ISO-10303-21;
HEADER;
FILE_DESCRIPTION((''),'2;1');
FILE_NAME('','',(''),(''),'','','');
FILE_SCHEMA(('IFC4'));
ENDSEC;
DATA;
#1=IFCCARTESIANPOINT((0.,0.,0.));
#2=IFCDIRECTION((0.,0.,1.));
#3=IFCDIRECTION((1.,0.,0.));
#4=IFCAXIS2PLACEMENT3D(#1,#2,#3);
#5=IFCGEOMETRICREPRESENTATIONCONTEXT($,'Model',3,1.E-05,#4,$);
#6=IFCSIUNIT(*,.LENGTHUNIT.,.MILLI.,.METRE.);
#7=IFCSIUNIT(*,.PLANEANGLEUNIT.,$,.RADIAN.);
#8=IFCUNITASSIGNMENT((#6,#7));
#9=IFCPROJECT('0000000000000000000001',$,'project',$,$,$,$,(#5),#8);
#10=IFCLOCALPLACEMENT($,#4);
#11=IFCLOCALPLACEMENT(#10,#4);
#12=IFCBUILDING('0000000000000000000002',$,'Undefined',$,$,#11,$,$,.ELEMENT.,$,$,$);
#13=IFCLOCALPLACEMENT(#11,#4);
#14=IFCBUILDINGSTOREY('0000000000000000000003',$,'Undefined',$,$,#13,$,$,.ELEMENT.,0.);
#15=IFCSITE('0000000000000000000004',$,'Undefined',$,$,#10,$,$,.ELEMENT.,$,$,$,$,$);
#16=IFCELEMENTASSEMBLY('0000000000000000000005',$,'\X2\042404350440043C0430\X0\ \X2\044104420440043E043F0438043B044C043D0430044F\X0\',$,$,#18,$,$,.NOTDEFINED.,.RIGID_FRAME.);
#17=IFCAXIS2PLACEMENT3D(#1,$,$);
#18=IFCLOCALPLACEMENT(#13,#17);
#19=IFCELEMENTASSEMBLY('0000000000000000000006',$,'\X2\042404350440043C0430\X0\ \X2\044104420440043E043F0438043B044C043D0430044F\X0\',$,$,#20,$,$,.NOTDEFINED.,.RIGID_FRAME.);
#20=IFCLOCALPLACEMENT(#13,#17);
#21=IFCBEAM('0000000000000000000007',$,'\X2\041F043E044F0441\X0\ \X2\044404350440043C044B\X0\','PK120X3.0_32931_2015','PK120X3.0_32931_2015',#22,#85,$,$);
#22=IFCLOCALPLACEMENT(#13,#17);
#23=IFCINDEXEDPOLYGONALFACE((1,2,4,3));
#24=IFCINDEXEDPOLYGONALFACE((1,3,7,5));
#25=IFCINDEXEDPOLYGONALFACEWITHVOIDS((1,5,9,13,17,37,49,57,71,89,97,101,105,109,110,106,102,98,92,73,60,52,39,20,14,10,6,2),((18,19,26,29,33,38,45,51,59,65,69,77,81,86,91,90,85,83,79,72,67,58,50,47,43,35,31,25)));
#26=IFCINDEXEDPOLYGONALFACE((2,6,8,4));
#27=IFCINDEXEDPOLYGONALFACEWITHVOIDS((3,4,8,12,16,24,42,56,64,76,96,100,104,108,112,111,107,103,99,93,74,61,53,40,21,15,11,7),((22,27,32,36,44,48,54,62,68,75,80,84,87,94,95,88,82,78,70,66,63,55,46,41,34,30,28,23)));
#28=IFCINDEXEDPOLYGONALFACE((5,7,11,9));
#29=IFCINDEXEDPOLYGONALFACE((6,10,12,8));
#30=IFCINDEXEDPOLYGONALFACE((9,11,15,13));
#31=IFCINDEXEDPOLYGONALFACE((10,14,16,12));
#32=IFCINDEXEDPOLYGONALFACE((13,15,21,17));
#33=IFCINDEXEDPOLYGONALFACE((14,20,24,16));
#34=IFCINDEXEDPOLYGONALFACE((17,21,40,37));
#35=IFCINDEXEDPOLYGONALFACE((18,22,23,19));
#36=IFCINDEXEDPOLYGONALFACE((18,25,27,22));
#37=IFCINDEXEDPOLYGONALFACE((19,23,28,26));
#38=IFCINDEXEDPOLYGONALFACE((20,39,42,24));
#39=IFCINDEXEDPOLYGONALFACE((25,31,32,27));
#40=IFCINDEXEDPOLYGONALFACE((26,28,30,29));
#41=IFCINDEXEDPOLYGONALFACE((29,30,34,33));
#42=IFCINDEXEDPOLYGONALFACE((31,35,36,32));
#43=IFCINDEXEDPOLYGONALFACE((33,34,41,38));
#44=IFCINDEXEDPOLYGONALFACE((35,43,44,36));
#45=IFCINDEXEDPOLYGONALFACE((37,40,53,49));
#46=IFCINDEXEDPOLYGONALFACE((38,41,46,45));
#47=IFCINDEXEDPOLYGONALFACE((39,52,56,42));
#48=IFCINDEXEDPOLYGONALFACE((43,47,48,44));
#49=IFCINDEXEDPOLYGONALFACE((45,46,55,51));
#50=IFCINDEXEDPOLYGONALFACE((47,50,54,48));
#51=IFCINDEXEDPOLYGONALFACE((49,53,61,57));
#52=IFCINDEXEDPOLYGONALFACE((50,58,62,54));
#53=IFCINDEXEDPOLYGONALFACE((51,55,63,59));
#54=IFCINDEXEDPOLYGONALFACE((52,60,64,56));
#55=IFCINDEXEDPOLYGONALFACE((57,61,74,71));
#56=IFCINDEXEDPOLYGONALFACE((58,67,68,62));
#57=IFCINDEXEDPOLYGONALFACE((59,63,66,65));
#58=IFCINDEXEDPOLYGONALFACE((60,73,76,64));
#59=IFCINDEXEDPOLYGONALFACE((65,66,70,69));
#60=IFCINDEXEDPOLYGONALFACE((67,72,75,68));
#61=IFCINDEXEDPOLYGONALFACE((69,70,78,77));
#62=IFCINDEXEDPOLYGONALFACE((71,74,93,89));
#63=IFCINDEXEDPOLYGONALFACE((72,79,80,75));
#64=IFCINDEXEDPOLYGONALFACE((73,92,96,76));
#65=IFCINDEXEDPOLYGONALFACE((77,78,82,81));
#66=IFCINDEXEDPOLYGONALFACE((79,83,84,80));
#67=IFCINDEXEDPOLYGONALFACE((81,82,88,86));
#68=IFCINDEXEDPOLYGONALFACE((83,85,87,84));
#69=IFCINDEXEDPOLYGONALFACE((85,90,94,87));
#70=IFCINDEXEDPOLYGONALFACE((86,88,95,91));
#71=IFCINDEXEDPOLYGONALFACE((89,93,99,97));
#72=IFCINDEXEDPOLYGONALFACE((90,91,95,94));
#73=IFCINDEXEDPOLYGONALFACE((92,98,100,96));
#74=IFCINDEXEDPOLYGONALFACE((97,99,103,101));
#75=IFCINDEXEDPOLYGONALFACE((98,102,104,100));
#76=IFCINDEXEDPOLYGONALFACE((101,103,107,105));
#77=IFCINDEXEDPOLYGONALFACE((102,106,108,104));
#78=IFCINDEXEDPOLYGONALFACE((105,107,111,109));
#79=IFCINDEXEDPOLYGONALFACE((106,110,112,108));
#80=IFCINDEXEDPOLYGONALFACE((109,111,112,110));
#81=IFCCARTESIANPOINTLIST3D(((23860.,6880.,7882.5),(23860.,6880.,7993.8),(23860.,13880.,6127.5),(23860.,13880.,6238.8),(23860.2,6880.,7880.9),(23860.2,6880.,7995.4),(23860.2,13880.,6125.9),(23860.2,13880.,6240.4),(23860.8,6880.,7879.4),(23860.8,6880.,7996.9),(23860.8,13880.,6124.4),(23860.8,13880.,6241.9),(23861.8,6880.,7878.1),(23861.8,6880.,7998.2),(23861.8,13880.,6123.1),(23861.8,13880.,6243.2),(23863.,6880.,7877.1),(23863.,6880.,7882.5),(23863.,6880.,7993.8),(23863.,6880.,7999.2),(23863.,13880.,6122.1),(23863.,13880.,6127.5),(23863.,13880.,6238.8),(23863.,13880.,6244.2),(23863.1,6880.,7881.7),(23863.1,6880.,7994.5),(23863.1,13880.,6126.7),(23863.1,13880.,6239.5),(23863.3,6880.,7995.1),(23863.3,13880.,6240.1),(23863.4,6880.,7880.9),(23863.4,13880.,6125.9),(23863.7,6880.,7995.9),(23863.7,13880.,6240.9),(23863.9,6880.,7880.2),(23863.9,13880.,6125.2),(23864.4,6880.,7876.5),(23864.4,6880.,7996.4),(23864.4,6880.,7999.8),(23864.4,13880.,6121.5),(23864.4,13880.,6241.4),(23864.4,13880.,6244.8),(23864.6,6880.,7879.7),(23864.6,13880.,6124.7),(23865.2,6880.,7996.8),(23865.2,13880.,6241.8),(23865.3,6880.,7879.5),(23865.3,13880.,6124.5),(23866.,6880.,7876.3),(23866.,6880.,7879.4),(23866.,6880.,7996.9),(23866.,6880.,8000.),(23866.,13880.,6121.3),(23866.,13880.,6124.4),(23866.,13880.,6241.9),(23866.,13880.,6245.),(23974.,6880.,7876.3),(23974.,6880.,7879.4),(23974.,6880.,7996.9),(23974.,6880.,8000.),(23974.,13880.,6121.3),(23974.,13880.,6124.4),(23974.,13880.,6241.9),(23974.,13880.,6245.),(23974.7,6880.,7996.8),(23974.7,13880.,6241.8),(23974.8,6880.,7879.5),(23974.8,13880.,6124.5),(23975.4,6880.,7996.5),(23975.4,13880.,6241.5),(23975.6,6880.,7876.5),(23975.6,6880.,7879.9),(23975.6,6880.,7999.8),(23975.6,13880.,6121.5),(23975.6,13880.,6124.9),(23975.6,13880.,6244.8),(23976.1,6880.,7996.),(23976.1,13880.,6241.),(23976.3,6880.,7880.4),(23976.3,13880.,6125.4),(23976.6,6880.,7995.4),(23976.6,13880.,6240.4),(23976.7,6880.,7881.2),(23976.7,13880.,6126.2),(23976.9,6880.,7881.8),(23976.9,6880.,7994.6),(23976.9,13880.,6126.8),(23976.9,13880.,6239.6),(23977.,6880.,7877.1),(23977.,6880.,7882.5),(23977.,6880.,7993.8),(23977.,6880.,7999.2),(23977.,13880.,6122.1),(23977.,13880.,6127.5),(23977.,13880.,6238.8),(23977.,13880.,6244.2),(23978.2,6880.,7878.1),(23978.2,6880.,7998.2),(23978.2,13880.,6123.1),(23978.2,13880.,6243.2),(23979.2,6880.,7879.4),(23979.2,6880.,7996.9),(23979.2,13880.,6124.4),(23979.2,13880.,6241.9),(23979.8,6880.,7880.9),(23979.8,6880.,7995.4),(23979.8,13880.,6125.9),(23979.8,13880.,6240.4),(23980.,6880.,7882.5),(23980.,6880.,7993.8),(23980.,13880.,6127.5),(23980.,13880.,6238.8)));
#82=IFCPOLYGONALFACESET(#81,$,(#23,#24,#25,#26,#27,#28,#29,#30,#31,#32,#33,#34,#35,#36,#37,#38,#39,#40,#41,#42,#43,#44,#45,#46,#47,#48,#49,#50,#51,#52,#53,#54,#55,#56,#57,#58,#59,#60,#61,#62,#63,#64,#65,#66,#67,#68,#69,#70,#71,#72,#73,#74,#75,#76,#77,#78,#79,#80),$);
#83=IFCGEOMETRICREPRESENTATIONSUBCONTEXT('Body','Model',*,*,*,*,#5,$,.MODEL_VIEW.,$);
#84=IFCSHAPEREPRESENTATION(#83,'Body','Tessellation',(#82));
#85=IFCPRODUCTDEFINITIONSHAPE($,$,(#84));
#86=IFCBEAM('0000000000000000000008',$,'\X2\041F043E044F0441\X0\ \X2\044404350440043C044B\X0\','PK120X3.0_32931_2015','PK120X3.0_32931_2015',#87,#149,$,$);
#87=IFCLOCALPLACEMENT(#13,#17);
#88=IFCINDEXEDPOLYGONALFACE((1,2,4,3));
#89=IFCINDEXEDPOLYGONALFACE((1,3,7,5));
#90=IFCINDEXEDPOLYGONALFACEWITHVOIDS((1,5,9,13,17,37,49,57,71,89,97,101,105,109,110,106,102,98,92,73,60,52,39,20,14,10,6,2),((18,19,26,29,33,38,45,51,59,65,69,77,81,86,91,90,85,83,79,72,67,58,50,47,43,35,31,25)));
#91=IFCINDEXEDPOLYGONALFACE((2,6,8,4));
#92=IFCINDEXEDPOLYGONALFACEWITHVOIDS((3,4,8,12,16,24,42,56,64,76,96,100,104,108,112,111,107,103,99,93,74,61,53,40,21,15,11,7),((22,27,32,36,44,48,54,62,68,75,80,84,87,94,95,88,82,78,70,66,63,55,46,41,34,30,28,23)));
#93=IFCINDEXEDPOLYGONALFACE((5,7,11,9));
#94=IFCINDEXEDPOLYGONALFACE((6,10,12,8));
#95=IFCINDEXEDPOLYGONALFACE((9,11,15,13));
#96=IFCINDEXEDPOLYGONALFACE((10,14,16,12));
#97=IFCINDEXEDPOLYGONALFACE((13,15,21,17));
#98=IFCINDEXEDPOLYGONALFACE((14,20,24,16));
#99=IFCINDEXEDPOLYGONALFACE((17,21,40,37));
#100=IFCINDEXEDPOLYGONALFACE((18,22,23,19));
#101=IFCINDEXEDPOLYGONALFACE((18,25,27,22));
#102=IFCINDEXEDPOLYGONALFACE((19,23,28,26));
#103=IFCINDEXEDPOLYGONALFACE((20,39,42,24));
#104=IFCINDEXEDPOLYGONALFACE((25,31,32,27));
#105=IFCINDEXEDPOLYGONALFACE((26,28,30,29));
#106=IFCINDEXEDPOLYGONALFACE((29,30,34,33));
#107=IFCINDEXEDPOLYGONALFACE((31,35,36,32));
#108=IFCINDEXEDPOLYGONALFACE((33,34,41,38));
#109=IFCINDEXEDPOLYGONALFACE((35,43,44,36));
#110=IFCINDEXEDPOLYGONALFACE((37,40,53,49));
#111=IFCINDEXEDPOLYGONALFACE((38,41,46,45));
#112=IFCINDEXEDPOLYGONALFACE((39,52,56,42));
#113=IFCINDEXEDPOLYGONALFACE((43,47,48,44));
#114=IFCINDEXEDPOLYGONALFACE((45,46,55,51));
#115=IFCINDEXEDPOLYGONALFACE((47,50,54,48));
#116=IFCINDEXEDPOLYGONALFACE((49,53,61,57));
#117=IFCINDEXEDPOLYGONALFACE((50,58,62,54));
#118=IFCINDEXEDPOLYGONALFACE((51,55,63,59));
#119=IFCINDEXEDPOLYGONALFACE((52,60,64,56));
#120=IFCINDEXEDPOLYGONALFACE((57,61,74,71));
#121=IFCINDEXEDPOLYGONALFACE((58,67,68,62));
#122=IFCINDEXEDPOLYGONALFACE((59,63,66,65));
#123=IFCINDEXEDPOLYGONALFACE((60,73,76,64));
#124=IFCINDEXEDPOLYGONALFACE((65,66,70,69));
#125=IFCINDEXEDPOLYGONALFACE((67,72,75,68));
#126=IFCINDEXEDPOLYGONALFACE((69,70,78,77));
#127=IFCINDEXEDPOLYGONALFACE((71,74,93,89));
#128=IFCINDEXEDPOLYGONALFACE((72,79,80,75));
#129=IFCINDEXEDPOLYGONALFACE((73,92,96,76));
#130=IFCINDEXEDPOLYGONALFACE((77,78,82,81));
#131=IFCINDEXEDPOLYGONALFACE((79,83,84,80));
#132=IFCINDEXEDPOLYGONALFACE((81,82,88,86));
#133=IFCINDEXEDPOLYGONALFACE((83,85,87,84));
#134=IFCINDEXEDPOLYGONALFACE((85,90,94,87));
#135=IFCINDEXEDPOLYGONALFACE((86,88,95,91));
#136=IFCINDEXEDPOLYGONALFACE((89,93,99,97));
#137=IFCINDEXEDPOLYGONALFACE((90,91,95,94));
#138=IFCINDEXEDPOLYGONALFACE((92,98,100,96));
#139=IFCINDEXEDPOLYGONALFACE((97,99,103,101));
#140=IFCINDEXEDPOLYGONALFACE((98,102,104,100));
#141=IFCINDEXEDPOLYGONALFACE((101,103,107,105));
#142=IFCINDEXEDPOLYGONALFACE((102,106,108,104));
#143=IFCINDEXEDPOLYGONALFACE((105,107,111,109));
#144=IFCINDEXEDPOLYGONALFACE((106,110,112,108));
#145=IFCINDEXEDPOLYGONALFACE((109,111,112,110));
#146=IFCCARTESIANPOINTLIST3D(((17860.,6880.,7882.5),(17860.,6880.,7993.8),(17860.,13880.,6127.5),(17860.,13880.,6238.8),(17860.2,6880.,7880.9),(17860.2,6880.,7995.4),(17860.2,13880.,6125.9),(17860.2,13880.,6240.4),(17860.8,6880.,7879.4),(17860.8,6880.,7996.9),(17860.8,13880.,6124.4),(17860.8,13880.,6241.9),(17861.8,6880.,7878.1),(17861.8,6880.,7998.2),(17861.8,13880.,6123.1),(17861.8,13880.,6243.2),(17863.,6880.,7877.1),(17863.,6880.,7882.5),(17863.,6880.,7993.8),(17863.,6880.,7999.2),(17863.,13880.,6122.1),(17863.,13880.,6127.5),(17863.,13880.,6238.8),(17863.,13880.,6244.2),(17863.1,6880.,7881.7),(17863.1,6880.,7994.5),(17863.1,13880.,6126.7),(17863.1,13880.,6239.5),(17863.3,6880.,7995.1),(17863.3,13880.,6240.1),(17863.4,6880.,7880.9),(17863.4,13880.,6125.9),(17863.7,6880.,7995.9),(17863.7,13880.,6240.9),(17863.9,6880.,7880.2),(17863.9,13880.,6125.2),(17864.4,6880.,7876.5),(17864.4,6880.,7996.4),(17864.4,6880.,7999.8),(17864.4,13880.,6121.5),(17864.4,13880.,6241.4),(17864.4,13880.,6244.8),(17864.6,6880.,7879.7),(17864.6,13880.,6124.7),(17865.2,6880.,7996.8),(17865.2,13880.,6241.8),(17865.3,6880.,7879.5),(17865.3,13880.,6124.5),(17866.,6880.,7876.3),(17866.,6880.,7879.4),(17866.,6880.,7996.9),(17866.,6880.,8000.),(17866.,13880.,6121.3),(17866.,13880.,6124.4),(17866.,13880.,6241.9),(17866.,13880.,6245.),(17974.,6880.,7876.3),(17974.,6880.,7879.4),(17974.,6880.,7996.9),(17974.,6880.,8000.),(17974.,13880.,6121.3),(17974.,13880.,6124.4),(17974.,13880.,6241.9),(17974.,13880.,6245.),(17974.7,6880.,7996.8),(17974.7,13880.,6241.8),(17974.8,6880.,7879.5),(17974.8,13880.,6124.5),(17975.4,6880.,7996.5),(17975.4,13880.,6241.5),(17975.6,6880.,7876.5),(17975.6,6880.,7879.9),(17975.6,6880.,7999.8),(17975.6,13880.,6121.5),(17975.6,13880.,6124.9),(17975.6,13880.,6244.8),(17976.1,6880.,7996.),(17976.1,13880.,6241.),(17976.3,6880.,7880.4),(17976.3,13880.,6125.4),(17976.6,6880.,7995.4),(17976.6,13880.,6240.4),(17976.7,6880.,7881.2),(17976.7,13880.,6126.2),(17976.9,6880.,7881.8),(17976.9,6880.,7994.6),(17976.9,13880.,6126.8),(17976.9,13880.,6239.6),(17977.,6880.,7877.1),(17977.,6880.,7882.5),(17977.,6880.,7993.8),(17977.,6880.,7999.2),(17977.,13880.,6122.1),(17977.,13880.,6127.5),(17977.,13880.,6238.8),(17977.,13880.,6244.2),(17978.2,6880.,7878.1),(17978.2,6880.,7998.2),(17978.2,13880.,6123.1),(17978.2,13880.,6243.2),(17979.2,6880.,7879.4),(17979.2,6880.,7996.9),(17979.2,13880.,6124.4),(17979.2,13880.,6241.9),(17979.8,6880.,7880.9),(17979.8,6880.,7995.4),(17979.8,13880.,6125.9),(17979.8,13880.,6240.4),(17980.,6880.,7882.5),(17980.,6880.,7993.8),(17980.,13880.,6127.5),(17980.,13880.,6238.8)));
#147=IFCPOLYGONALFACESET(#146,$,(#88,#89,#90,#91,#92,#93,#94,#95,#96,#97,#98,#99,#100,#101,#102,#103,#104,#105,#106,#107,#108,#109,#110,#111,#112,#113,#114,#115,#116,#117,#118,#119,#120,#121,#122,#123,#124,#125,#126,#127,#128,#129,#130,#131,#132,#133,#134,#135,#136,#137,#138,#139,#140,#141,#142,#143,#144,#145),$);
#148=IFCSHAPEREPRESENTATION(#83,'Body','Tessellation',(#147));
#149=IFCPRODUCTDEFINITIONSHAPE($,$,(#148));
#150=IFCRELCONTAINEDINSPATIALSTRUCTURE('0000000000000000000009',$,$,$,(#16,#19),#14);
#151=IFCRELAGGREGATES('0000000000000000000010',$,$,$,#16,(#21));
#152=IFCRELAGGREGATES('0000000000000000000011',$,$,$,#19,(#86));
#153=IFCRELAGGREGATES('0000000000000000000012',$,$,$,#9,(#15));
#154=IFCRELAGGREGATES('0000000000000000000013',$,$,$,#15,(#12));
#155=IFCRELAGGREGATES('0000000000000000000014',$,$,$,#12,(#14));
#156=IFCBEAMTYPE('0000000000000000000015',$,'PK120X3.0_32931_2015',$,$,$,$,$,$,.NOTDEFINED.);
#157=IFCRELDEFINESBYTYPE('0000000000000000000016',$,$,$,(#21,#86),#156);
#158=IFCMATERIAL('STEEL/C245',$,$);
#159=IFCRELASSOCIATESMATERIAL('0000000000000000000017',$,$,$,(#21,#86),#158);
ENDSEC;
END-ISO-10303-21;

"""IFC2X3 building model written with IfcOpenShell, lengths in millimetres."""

from ifc_helpers import new_model, si_unit, frame, origin_with_axes, origin_2d_with_axis, place, context, subcontext, project, spatial, hollow_rectangle, extrude, clip, halfspace, material, type_object, element, aggregate, save


model = new_model("IFC2X3")

# Units and contexts
model_context = context("Model", 3, precision=1e-05, world=origin_with_axes())
body_context = subcontext(model_context, "Body", "Model", "MODEL_VIEW")
ifc_project = project(units=[si_unit("LENGTHUNIT", "METRE", prefix="MILLI"), si_unit("PLANEANGLEUNIT", "RADIAN")], contexts=[model_context])

# Site, building, storey
site_placement = place(None, origin_with_axes())
site = spatial("IfcSite", under=ifc_project, at=site_placement, Name="Undefined", CompositionType="ELEMENT")
building_placement = place(site_placement, origin_with_axes())
building = spatial("IfcBuilding", under=site, at=building_placement, Name="Undefined", CompositionType="ELEMENT")
storey_placement = place(building_placement, origin_with_axes())
storey = spatial("IfcBuildingStorey", under=building, at=storey_placement, Name="Undefined", CompositionType="ELEMENT", Elevation=0.0)

# Shared definitions
ifc_material = material(Name="STEEL/C245")

# Element assemblies
assembly_1_placement = place(storey_placement, origin_with_axes())
assembly_1 = element("IfcElementAssembly", 1, at=assembly_1_placement, inside=storey, Name="Ферма стропильная", AssemblyPlace="NOTDEFINED", PredefinedType="RIGID_FRAME")
assembly_2_placement = place(storey_placement, origin_with_axes())
assembly_2 = element("IfcElementAssembly", 2, at=assembly_2_placement, inside=storey, Name="Ферма стропильная", AssemblyPlace="NOTDEFINED", PredefinedType="RIGID_FRAME")

# Beams
beam_type_1 = type_object("IfcBeamType", Name="PK120X3.0_32931_2015", PredefinedType="NOTDEFINED")
beam_1_placement = place(assembly_1_placement, frame((23920.0, 13865.4, 6186.8), z_axis=(0.0, 0.243188, 0.969979), x_axis=(0.0, -0.969979, 0.243188)))
beam_1 = element("IfcBeam", 3, at=beam_1_placement, type_object=beam_type_1, material=ifc_material, Name="Пояс фермы", Description="PK120X3.0_32931_2015", ObjectType="PK120X3.0_32931_2015", context=body_context, shape_type="Clipping", body=[
    clip(clip(extrude(hollow_rectangle(XDim=120.0, YDim=120.0, WallThickness=3.0, InnerFilletRadius=3.0, OuterFilletRadius=6.0, at=origin_2d_with_axis()), frame((7232.0, 0.0, 0.0), z_axis=(-1.0, 0.0, 0.0), x_axis=(0.0, -1.0, 0.0)), (0.0, 0.0, 1.0), 7277.4), halfspace(frame((7216.6, 0.0, 60.0), z_axis=(0.969979, 0.0, -0.243188), x_axis=(0.243188, 0.0, 0.969979)), False)), halfspace(frame((0.0, 0.0, 60.0), z_axis=(0.969979, 0.0, -0.243188), x_axis=(0.243188, 0.0, 0.969979)), True)),
])
aggregate(assembly_1, [beam_1])
beam_2_placement = place(assembly_2_placement, frame((17920.0, 13865.4, 6186.8), z_axis=(0.0, 0.243188, 0.969979), x_axis=(0.0, -0.969979, 0.243188)))
beam_2 = element("IfcBeam", 4, at=beam_2_placement, type_object=beam_type_1, material=ifc_material, Name="Пояс фермы", Description="PK120X3.0_32931_2015", ObjectType="PK120X3.0_32931_2015", context=body_context, shape_type="Clipping", body=[
    clip(clip(extrude(hollow_rectangle(XDim=120.0, YDim=120.0, WallThickness=3.0, InnerFilletRadius=3.0, OuterFilletRadius=6.0, at=origin_2d_with_axis()), frame((7232.0, 0.0, 0.0), z_axis=(-1.0, 0.0, 0.0), x_axis=(0.0, -1.0, 0.0)), (0.0, 0.0, 1.0), 7277.4), halfspace(frame((7216.6, 0.0, 60.0), z_axis=(0.969979, 0.0, -0.243188), x_axis=(0.243188, 0.0, 0.969979)), False)), halfspace(frame((0.0, 0.0, 60.0), z_axis=(0.969979, 0.0, -0.243188), x_axis=(0.243188, 0.0, 0.969979)), True)),
])
aggregate(assembly_2, [beam_2])

save(model, "model.ifc")
